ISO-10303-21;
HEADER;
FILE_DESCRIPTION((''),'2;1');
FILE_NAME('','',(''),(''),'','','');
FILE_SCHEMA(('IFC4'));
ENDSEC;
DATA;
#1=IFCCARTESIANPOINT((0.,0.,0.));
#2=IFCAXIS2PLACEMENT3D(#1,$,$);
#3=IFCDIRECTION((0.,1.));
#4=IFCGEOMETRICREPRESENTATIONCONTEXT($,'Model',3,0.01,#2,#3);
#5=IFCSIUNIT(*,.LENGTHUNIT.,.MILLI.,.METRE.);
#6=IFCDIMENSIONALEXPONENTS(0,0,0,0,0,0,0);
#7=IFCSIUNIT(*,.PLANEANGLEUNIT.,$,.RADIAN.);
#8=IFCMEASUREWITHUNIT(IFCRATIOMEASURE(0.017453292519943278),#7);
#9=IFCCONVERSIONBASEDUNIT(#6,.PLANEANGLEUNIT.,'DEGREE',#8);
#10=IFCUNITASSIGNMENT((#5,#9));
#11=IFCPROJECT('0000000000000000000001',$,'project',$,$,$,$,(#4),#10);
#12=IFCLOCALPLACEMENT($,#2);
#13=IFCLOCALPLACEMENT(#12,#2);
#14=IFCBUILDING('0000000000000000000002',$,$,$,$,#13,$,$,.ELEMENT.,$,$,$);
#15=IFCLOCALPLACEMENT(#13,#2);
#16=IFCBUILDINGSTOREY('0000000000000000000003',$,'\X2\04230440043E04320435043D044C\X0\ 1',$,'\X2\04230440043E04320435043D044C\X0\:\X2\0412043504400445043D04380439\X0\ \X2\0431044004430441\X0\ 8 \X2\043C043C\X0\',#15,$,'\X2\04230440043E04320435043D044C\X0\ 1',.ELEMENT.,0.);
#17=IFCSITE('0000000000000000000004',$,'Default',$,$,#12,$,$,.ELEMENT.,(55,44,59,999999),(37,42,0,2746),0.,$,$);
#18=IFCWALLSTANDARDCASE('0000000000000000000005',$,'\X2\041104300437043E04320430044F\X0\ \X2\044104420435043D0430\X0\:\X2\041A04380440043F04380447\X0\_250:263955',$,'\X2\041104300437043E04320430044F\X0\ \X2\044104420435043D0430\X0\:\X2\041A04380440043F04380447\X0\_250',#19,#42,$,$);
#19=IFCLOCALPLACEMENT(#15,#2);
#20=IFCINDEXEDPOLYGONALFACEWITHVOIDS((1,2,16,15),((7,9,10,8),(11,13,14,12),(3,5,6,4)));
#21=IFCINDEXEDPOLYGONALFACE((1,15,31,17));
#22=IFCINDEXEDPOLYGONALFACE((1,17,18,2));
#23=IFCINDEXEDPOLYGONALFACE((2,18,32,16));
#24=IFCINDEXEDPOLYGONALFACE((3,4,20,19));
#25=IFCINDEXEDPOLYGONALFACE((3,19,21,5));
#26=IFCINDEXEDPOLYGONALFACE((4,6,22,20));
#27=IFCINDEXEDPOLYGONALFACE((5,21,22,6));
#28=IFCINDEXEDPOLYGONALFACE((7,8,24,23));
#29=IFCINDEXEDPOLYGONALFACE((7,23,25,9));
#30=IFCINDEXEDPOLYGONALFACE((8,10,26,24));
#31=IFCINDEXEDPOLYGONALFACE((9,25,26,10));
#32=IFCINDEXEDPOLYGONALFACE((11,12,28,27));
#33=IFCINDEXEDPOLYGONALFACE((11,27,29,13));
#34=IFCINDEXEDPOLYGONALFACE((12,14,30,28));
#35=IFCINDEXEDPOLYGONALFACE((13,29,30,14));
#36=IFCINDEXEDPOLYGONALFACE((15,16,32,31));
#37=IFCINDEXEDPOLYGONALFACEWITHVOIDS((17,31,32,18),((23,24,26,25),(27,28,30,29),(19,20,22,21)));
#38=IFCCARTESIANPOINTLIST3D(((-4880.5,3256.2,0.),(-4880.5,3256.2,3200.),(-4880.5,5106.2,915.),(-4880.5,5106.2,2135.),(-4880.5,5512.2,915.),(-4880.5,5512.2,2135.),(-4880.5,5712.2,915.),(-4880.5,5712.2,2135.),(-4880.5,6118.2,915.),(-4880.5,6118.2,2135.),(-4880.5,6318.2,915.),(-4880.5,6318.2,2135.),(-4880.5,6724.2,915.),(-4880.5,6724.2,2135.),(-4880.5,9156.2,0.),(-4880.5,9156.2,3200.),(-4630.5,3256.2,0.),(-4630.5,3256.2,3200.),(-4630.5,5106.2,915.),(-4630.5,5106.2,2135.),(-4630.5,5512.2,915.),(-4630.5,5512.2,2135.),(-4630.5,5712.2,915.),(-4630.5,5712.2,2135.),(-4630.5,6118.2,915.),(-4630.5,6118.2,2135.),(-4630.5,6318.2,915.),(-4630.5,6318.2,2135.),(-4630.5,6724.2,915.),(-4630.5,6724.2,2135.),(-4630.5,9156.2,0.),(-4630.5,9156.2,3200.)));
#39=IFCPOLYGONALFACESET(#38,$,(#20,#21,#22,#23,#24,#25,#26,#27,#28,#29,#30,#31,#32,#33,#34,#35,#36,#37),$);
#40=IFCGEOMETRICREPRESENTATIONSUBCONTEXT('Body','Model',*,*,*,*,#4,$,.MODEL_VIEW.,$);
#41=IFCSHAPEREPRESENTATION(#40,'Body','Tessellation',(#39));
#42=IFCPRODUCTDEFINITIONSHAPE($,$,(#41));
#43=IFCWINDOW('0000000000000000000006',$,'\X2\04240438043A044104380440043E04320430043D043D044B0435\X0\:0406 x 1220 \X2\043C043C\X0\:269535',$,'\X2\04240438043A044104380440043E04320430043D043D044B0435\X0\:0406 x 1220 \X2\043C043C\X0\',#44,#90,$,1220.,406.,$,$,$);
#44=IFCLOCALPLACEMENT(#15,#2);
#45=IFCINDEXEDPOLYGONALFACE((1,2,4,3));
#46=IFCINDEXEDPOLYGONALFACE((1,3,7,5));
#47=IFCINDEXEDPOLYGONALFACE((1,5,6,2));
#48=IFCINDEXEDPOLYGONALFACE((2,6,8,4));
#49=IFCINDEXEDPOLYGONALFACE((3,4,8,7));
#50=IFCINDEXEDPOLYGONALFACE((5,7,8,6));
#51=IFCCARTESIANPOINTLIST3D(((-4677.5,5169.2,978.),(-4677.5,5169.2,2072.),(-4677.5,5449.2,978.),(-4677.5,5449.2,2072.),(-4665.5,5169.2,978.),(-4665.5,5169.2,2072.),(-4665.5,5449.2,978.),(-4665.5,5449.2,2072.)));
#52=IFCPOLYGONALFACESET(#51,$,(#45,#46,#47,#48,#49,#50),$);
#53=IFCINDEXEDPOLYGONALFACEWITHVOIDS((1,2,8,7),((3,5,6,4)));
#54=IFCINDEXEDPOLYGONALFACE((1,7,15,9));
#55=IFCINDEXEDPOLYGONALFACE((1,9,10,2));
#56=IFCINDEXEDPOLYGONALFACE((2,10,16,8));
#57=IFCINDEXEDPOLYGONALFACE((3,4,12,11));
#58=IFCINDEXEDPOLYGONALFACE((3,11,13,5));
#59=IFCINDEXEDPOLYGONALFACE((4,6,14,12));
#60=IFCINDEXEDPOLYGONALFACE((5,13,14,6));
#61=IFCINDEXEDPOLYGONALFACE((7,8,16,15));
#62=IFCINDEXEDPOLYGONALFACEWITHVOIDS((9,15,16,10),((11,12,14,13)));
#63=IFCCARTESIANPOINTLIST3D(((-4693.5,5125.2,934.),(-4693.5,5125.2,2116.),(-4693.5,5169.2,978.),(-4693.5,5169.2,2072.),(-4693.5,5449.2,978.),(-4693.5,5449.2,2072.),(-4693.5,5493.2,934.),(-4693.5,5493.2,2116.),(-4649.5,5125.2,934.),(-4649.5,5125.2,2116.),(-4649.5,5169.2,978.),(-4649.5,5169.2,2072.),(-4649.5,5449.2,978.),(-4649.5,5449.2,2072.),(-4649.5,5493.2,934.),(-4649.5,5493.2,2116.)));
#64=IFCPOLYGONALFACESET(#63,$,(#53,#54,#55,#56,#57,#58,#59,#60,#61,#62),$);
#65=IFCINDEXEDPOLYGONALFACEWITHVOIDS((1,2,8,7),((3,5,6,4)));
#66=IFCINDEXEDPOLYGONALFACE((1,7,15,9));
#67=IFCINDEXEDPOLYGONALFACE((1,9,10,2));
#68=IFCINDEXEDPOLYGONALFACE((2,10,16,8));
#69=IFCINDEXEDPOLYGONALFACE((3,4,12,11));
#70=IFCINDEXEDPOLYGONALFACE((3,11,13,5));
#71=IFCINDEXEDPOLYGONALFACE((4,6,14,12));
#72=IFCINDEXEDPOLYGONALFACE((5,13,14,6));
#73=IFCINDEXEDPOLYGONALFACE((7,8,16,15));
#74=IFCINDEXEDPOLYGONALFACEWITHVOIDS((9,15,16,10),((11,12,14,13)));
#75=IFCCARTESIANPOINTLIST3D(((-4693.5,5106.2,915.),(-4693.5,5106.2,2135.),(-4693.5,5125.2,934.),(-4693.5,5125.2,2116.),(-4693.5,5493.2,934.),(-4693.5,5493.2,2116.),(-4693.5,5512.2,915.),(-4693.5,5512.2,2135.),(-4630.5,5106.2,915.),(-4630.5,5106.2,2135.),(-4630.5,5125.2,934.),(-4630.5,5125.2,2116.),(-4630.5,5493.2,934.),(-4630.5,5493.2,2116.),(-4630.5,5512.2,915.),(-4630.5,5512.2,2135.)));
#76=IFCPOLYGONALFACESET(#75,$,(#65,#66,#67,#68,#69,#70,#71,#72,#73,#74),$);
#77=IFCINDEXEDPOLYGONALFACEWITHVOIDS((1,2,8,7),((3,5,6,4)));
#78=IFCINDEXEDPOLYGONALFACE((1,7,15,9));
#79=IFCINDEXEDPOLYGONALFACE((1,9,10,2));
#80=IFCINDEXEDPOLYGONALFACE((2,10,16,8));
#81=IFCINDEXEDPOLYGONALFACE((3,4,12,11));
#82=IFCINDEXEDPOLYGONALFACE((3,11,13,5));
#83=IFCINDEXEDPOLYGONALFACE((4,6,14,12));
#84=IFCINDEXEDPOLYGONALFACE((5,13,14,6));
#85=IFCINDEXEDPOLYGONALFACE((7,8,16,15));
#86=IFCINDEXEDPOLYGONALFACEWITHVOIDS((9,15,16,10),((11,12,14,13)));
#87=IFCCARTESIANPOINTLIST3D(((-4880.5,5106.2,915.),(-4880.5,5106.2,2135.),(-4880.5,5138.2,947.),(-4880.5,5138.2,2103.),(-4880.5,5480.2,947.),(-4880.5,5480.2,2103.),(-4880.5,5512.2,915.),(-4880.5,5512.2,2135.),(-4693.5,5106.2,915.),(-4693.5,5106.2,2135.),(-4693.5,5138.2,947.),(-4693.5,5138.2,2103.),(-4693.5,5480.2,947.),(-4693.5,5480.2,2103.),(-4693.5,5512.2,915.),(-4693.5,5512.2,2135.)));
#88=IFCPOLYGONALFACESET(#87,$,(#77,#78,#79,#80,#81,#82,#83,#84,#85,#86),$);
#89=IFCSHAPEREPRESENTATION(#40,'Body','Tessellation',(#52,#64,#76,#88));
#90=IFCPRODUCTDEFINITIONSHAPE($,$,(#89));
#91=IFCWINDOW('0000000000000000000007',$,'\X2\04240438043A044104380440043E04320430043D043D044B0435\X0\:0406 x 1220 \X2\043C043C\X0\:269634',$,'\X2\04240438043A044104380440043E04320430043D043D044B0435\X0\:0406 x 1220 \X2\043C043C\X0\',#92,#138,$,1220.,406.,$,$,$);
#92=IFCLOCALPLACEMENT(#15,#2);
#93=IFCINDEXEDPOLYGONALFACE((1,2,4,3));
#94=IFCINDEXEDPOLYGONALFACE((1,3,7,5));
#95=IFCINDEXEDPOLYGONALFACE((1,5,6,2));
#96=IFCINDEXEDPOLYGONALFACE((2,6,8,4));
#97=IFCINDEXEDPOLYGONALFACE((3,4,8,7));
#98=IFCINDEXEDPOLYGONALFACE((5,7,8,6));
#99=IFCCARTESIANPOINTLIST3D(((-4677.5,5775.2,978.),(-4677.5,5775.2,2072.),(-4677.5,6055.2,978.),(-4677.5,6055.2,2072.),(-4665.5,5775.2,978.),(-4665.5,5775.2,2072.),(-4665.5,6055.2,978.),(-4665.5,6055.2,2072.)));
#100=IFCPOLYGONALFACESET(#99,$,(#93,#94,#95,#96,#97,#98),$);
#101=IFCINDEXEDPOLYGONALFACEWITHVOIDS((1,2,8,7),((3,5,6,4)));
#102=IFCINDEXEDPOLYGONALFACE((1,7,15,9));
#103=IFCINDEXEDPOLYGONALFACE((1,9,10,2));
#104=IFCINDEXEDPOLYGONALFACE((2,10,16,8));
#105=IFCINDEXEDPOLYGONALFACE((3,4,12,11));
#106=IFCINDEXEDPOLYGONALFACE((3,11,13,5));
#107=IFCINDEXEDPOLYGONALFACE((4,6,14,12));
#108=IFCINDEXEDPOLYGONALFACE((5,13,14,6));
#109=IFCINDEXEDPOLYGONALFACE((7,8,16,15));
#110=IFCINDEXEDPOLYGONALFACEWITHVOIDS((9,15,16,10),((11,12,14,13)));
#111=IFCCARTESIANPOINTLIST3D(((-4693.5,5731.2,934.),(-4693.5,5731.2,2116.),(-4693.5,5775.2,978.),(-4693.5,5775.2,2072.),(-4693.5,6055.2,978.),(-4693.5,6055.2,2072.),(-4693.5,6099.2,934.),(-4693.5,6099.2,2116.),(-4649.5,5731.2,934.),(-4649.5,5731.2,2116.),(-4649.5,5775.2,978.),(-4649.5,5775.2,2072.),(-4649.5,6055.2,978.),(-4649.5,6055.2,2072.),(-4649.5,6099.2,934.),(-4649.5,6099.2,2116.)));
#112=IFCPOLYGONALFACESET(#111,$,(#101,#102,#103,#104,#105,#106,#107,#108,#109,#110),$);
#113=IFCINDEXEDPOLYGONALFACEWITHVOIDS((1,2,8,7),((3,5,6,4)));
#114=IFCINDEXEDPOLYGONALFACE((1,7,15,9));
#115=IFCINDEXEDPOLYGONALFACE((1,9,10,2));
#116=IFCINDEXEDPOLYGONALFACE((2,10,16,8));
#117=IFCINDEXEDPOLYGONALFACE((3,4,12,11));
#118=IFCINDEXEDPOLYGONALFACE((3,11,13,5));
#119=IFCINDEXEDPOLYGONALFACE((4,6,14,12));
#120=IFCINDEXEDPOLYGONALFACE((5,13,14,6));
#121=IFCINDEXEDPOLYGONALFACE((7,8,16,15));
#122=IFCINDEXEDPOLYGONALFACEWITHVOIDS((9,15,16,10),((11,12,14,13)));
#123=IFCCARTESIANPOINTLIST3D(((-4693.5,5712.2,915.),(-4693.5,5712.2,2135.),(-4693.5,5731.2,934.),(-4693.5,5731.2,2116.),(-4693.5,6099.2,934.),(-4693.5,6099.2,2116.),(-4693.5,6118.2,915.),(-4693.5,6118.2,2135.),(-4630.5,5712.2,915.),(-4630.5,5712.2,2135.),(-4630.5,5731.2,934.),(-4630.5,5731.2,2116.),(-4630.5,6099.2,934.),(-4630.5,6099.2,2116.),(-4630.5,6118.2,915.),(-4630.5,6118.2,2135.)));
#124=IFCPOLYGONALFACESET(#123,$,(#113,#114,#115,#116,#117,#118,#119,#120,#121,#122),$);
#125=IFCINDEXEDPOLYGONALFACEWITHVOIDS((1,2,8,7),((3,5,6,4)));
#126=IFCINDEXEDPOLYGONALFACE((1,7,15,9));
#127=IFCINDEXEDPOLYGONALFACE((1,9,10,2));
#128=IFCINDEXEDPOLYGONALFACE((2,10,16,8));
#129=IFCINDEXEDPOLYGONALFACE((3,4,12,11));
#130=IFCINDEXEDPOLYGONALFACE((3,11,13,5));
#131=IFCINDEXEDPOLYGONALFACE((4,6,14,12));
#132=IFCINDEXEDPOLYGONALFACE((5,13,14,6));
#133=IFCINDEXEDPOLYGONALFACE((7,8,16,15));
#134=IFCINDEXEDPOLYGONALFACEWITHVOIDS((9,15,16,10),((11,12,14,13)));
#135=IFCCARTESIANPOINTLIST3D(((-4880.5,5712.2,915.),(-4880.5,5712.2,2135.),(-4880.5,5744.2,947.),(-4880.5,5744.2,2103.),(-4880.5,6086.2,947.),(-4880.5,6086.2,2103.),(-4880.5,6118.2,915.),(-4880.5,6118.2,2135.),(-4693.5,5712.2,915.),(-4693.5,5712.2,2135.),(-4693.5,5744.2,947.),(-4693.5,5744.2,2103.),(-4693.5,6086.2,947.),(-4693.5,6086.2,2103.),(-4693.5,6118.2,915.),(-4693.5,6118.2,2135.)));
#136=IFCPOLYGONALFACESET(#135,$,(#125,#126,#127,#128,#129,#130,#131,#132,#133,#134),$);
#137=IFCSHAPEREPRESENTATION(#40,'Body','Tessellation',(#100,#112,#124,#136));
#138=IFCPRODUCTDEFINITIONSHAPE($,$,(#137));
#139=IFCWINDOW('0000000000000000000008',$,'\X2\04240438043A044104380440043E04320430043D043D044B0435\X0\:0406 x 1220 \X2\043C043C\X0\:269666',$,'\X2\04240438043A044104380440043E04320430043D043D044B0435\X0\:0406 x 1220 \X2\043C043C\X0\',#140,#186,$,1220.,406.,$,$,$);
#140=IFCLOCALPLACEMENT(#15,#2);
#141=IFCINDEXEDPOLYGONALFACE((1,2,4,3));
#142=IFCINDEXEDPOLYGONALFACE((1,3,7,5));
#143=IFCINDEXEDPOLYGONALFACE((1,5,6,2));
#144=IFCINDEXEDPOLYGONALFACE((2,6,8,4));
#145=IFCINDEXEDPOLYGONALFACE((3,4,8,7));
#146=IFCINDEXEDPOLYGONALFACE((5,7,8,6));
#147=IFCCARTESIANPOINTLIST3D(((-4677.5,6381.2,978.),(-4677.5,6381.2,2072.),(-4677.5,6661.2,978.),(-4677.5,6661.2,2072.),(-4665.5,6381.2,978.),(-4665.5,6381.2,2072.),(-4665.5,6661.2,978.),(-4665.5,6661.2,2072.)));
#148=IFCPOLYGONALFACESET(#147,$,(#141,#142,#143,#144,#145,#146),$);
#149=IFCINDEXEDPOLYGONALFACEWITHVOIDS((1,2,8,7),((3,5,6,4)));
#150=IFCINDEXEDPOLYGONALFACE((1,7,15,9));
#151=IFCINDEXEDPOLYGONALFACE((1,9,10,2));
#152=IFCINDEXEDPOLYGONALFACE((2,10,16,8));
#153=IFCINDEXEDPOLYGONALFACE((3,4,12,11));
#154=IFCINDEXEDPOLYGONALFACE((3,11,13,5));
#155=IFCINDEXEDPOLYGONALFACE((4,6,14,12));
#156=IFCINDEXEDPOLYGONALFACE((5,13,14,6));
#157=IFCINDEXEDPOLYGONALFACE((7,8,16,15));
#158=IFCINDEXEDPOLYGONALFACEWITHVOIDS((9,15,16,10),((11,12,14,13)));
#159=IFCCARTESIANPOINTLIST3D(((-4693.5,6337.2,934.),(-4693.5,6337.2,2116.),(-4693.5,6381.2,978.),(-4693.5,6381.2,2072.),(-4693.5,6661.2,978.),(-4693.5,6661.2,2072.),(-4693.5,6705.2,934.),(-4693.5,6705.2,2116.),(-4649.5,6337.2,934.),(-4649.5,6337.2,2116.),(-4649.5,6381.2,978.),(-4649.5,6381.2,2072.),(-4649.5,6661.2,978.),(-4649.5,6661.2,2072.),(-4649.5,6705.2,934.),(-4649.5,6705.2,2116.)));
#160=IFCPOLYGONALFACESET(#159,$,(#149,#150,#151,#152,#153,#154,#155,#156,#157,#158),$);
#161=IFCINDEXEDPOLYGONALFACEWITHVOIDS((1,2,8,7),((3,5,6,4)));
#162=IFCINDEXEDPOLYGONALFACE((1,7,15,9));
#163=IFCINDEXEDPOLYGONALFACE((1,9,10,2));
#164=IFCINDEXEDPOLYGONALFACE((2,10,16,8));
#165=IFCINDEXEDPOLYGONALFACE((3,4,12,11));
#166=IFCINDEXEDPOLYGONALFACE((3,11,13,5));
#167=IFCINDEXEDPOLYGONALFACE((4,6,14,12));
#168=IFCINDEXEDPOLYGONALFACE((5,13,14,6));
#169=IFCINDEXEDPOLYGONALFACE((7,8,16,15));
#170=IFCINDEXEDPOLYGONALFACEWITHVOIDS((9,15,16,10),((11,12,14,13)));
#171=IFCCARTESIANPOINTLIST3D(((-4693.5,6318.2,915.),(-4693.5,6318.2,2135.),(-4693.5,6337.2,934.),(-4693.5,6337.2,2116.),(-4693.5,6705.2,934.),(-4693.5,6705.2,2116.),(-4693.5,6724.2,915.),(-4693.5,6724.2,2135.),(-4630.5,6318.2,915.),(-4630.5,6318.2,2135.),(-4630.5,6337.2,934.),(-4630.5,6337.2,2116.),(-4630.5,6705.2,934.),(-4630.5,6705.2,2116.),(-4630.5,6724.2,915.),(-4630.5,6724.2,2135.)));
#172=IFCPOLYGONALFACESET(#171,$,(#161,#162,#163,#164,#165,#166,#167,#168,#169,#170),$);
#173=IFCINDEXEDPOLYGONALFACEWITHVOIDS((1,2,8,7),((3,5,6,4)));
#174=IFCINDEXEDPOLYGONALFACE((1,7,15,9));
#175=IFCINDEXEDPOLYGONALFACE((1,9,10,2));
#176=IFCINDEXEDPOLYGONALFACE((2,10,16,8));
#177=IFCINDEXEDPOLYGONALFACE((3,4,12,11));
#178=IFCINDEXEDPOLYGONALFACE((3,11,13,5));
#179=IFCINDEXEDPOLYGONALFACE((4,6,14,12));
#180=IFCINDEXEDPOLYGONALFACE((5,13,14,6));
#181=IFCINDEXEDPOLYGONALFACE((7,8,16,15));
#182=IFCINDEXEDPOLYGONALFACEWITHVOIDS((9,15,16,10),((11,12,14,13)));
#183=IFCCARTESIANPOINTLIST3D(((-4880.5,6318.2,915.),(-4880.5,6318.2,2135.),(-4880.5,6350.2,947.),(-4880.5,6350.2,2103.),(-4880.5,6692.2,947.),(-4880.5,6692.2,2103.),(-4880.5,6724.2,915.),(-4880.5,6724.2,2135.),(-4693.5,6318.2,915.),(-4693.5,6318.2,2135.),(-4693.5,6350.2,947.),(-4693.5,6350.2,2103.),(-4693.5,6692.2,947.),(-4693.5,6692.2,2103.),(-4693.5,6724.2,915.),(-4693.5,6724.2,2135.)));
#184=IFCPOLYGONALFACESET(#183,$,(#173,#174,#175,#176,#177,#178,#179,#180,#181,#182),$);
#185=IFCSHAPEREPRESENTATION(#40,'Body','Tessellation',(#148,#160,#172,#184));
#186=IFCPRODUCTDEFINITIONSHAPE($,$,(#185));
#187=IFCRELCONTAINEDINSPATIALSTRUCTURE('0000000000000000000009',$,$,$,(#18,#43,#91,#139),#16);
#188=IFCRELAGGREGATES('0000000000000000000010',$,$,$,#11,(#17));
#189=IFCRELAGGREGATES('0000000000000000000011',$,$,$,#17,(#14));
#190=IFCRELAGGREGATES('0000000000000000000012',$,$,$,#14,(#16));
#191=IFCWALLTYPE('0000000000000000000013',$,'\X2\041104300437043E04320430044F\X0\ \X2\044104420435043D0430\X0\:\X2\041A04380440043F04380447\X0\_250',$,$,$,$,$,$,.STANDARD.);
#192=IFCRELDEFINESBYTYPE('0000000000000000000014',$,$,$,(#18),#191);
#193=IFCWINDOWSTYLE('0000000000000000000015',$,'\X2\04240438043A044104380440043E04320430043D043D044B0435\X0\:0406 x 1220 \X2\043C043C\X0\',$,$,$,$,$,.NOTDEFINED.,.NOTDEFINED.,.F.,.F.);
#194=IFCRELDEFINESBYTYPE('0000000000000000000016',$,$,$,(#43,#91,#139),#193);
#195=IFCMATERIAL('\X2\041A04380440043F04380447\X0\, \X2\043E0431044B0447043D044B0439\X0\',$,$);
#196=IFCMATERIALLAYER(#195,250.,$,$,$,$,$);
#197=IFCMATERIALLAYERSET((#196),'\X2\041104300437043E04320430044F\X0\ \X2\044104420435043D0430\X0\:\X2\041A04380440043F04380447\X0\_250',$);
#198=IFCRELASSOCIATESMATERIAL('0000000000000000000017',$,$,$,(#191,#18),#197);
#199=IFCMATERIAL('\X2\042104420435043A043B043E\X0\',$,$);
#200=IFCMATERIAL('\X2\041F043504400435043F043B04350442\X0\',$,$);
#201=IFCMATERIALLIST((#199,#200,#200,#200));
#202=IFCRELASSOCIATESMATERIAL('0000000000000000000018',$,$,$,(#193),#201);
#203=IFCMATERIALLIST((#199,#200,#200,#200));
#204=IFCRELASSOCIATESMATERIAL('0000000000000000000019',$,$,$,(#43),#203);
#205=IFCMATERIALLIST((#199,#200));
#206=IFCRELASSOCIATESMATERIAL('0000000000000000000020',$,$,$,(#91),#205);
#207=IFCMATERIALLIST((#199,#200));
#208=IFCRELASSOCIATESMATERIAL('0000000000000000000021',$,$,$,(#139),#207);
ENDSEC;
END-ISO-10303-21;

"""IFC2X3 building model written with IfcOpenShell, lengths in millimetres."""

from ifc_helpers import new_model, entity, si_unit, converted_unit, direction, frame, frame_2d, origin, place, context, subcontext, project, spatial, polyline, rectangle, outline, extrude, source, transform, mapped, material, material_list, layer, layer_set, layer_usage, type_object, type_shapes, element, fill, save


model = new_model("IFC2X3")

# Units and contexts
model_context = context("Model", 3, precision=0.01, world=origin(), true_north=direction((0.0, 1.0)))
body_context = subcontext(model_context, "Body", "Model", "MODEL_VIEW")
ifc_project = project(units=[si_unit("LENGTHUNIT", "METRE", prefix="MILLI"), converted_unit("PLANEANGLEUNIT", "DEGREE", entity("IfcRatioMeasure", 0.017453292519943278), si_unit("PLANEANGLEUNIT", "RADIAN"), dimensions=[0, 0, 0, 0, 0, 0, 0])], contexts=[model_context])

# Site, building, storey
site_placement = place(None, origin())
site = spatial("IfcSite", under=ifc_project, at=site_placement, Name="Default", CompositionType="ELEMENT", RefLatitude=(55, 44, 59, 999999), RefLongitude=(37, 42, 0, 2746), RefElevation=0.0)
building_placement = place(site_placement, origin())
building = spatial("IfcBuilding", under=site, at=building_placement, CompositionType="ELEMENT")
storey_placement = place(building_placement, origin())
storey = spatial("IfcBuildingStorey", under=building, at=storey_placement, Name="Уровень 1", ObjectType="Уровень:Верхний брус 8 мм", LongName="Уровень 1", CompositionType="ELEMENT", Elevation=0.0)

# Shared definitions
ifc_material_1 = material(Name="Кирпич, обычный")
ifc_layer_1 = layer(ifc_material_1, 250.0)
ifc_layer_set_1 = layer_set([ifc_layer_1], Name="Базовая стена:Кирпич_250")
wall_type_1 = type_object("IfcWallType", Name="Базовая стена:Кирпич_250", PredefinedType="STANDARD", material=ifc_layer_set_1)

# Wall, openings, windows
ifc_layer_usage_1 = layer_usage(ifc_layer_set_1, "AXIS2", "NEGATIVE", 125.0)
wall_1_placement = place(storey_placement, frame((-4755.5, 3256.2, 0.0), z_axis=(0.0, 0.0, 1.0), x_axis=(0.0, 1.0, 0.0)))
wall_1 = element("IfcWallStandardCase", 1, at=wall_1_placement, inside=storey, type_object=wall_type_1, material=ifc_layer_usage_1, Name="Базовая стена:Кирпич_250:263955", ObjectType="Базовая стена:Кирпич_250", context=body_context, shape_type="SweptSolid", body=[
    extrude(rectangle(XDim=5900.0, YDim=250.0, at=frame_2d((2950.0, 0.0), x_axis=(-1.0, 0.0))), origin(), (0.0, 0.0, 1.0), 3200.0),
])
opening_1_placement = place(wall_1_placement, frame((2256.0, 125.0, 915.0)))
opening_1 = element("IfcOpeningElement", 2, at=opening_1_placement, cuts=wall_1, ObjectType="Opening", context=body_context, shape_type="SweptSolid", body=[
    extrude(rectangle(XDim=1220.0, YDim=406.0, at=frame_2d((610.0, 203.0), x_axis=(1.0, 0.0))), frame((0.0, 0.0, 0.0), z_axis=(0.0, -1.0, 0.0), x_axis=(0.0, 0.0, 1.0)), (0.0, 0.0, 1.0), 250.0),
])
opening_2_placement = place(wall_1_placement, frame((2862.0, 125.0, 915.0)))
opening_2 = element("IfcOpeningElement", 3, at=opening_2_placement, cuts=wall_1, ObjectType="Opening", context=body_context, shape_type="SweptSolid", body=[
    extrude(rectangle(XDim=1220.0, YDim=406.0, at=frame_2d((610.0, 203.0), x_axis=(1.0, 0.0))), frame((0.0, 0.0, 0.0), z_axis=(0.0, -1.0, 0.0), x_axis=(0.0, 0.0, 1.0)), (0.0, 0.0, 1.0), 250.0),
])
opening_3_placement = place(wall_1_placement, frame((3468.0, 125.0, 915.0)))
opening_3 = element("IfcOpeningElement", 4, at=opening_3_placement, cuts=wall_1, ObjectType="Opening", context=body_context, shape_type="SweptSolid", body=[
    extrude(rectangle(XDim=1220.0, YDim=406.0, at=frame_2d((610.0, 203.0), x_axis=(1.0, 0.0))), frame((0.0, 0.0, 0.0), z_axis=(0.0, -1.0, 0.0), x_axis=(0.0, 0.0, 1.0)), (0.0, 0.0, 1.0), 250.0),
])
ifc_material_2 = material(Name="Стекло")
ifc_material_3 = material(Name="Переплет")
ifc_material_list_1 = material_list([ifc_material_2, ifc_material_3, ifc_material_3, ifc_material_3])
ifc_material_list_2 = material_list([ifc_material_2, ifc_material_3, ifc_material_3, ifc_material_3])
window_style = type_object("IfcWindowStyle", Name="Фиксированные:0406 x 1220 мм", ConstructionType="NOTDEFINED", OperationType="NOTDEFINED", ParameterTakesPrecedence=False, Sizeable=False, material=ifc_material_list_2)
shared_shape_1 = source(origin(), body_context, "Body", "SweptSolid", [
    extrude(rectangle(XDim=12.0, YDim=280.0, at=frame_2d((0.0, 0.0), x_axis=(1.0, 0.0))), frame((203.0, 209.0, 63.0), z_axis=(0.0, 0.0, 1.0), x_axis=(0.0, -1.0, 0.0)), (0.0, 0.0, 1.0), 1094.0),
    extrude(outline(polyline([(-184.0, -591.0), (184.0, -591.0), (184.0, 591.0), (-184.0, 591.0), (-184.0, -591.0)]), holes=[polyline([(-140.0, -547.0), (-140.0, 547.0), (140.0, 547.0), (140.0, -547.0), (-140.0, -547.0)])]), frame((203.0, 187.0, 610.0), z_axis=(0.0, 1.0, 0.0), x_axis=(1.0, 0.0, 0.0)), (0.0, 0.0, 1.0), 44.0),
    extrude(outline(polyline([(-203.0, -610.0), (203.0, -610.0), (203.0, 610.0), (-203.0, 610.0), (-203.0, -610.0)]), holes=[polyline([(-184.0, -591.0), (-184.0, 591.0), (184.0, 591.0), (184.0, -591.0), (-184.0, -591.0)])]), frame((203.0, 187.0, 610.0), z_axis=(0.0, 1.0, 0.0), x_axis=(1.0, 0.0, 0.0)), (0.0, 0.0, 1.0), 63.0),
    extrude(outline(polyline([(-203.0, -610.0), (203.0, -610.0), (203.0, 610.0), (-203.0, 610.0), (-203.0, -610.0)]), holes=[polyline([(-171.0, -578.0), (-171.0, 578.0), (171.0, 578.0), (171.0, -578.0), (-171.0, -578.0)])]), frame((203.0, 0.0, 610.0), z_axis=(0.0, 1.0, 0.0), x_axis=(1.0, 0.0, 0.0)), (0.0, 0.0, 1.0), 187.0),
])
type_shapes(window_style, [shared_shape_1])
window_1_placement = place(opening_1_placement, frame((0.0, 0.0, 0.0), z_axis=(0.0, 0.0, 1.0), x_axis=(-1.0, 0.0, 0.0)))
window_1 = element("IfcWindow", 5, at=window_1_placement, inside=storey, type_object=window_style, material=ifc_material_list_1, Name="Фиксированные:0406 x 1220 мм:269535", ObjectType="Фиксированные:0406 x 1220 мм", OverallHeight=1220.0, OverallWidth=406.0, context=body_context, shape_type="MappedRepresentation", body=[
    mapped(shared_shape_1, transform((0.0, 0.0, 0.0), scale=1.0)),
])
fill(opening_1, window_1)
ifc_material_list_3 = material_list([ifc_material_2, ifc_material_3])
window_2_placement = place(opening_2_placement, frame((0.0, 0.0, 0.0), z_axis=(0.0, 0.0, 1.0), x_axis=(-1.0, 0.0, 0.0)))
window_2 = element("IfcWindow", 6, at=window_2_placement, inside=storey, type_object=window_style, material=ifc_material_list_3, Name="Фиксированные:0406 x 1220 мм:269634", ObjectType="Фиксированные:0406 x 1220 мм", OverallHeight=1220.0, OverallWidth=406.0, context=body_context, shape_type="MappedRepresentation", body=[
    mapped(shared_shape_1, transform((0.0, 0.0, 0.0), scale=1.0)),
])
fill(opening_2, window_2)
ifc_material_list_4 = material_list([ifc_material_2, ifc_material_3])
window_3_placement = place(opening_3_placement, frame((0.0, 0.0, 0.0), z_axis=(0.0, 0.0, 1.0), x_axis=(-1.0, 0.0, 0.0)))
window_3 = element("IfcWindow", 7, at=window_3_placement, inside=storey, type_object=window_style, material=ifc_material_list_4, Name="Фиксированные:0406 x 1220 мм:269666", ObjectType="Фиксированные:0406 x 1220 мм", OverallHeight=1220.0, OverallWidth=406.0, context=body_context, shape_type="MappedRepresentation", body=[
    mapped(shared_shape_1, transform((0.0, 0.0, 0.0), scale=1.0)),
])
fill(opening_3, window_3)

save(model, "model.ifc")
